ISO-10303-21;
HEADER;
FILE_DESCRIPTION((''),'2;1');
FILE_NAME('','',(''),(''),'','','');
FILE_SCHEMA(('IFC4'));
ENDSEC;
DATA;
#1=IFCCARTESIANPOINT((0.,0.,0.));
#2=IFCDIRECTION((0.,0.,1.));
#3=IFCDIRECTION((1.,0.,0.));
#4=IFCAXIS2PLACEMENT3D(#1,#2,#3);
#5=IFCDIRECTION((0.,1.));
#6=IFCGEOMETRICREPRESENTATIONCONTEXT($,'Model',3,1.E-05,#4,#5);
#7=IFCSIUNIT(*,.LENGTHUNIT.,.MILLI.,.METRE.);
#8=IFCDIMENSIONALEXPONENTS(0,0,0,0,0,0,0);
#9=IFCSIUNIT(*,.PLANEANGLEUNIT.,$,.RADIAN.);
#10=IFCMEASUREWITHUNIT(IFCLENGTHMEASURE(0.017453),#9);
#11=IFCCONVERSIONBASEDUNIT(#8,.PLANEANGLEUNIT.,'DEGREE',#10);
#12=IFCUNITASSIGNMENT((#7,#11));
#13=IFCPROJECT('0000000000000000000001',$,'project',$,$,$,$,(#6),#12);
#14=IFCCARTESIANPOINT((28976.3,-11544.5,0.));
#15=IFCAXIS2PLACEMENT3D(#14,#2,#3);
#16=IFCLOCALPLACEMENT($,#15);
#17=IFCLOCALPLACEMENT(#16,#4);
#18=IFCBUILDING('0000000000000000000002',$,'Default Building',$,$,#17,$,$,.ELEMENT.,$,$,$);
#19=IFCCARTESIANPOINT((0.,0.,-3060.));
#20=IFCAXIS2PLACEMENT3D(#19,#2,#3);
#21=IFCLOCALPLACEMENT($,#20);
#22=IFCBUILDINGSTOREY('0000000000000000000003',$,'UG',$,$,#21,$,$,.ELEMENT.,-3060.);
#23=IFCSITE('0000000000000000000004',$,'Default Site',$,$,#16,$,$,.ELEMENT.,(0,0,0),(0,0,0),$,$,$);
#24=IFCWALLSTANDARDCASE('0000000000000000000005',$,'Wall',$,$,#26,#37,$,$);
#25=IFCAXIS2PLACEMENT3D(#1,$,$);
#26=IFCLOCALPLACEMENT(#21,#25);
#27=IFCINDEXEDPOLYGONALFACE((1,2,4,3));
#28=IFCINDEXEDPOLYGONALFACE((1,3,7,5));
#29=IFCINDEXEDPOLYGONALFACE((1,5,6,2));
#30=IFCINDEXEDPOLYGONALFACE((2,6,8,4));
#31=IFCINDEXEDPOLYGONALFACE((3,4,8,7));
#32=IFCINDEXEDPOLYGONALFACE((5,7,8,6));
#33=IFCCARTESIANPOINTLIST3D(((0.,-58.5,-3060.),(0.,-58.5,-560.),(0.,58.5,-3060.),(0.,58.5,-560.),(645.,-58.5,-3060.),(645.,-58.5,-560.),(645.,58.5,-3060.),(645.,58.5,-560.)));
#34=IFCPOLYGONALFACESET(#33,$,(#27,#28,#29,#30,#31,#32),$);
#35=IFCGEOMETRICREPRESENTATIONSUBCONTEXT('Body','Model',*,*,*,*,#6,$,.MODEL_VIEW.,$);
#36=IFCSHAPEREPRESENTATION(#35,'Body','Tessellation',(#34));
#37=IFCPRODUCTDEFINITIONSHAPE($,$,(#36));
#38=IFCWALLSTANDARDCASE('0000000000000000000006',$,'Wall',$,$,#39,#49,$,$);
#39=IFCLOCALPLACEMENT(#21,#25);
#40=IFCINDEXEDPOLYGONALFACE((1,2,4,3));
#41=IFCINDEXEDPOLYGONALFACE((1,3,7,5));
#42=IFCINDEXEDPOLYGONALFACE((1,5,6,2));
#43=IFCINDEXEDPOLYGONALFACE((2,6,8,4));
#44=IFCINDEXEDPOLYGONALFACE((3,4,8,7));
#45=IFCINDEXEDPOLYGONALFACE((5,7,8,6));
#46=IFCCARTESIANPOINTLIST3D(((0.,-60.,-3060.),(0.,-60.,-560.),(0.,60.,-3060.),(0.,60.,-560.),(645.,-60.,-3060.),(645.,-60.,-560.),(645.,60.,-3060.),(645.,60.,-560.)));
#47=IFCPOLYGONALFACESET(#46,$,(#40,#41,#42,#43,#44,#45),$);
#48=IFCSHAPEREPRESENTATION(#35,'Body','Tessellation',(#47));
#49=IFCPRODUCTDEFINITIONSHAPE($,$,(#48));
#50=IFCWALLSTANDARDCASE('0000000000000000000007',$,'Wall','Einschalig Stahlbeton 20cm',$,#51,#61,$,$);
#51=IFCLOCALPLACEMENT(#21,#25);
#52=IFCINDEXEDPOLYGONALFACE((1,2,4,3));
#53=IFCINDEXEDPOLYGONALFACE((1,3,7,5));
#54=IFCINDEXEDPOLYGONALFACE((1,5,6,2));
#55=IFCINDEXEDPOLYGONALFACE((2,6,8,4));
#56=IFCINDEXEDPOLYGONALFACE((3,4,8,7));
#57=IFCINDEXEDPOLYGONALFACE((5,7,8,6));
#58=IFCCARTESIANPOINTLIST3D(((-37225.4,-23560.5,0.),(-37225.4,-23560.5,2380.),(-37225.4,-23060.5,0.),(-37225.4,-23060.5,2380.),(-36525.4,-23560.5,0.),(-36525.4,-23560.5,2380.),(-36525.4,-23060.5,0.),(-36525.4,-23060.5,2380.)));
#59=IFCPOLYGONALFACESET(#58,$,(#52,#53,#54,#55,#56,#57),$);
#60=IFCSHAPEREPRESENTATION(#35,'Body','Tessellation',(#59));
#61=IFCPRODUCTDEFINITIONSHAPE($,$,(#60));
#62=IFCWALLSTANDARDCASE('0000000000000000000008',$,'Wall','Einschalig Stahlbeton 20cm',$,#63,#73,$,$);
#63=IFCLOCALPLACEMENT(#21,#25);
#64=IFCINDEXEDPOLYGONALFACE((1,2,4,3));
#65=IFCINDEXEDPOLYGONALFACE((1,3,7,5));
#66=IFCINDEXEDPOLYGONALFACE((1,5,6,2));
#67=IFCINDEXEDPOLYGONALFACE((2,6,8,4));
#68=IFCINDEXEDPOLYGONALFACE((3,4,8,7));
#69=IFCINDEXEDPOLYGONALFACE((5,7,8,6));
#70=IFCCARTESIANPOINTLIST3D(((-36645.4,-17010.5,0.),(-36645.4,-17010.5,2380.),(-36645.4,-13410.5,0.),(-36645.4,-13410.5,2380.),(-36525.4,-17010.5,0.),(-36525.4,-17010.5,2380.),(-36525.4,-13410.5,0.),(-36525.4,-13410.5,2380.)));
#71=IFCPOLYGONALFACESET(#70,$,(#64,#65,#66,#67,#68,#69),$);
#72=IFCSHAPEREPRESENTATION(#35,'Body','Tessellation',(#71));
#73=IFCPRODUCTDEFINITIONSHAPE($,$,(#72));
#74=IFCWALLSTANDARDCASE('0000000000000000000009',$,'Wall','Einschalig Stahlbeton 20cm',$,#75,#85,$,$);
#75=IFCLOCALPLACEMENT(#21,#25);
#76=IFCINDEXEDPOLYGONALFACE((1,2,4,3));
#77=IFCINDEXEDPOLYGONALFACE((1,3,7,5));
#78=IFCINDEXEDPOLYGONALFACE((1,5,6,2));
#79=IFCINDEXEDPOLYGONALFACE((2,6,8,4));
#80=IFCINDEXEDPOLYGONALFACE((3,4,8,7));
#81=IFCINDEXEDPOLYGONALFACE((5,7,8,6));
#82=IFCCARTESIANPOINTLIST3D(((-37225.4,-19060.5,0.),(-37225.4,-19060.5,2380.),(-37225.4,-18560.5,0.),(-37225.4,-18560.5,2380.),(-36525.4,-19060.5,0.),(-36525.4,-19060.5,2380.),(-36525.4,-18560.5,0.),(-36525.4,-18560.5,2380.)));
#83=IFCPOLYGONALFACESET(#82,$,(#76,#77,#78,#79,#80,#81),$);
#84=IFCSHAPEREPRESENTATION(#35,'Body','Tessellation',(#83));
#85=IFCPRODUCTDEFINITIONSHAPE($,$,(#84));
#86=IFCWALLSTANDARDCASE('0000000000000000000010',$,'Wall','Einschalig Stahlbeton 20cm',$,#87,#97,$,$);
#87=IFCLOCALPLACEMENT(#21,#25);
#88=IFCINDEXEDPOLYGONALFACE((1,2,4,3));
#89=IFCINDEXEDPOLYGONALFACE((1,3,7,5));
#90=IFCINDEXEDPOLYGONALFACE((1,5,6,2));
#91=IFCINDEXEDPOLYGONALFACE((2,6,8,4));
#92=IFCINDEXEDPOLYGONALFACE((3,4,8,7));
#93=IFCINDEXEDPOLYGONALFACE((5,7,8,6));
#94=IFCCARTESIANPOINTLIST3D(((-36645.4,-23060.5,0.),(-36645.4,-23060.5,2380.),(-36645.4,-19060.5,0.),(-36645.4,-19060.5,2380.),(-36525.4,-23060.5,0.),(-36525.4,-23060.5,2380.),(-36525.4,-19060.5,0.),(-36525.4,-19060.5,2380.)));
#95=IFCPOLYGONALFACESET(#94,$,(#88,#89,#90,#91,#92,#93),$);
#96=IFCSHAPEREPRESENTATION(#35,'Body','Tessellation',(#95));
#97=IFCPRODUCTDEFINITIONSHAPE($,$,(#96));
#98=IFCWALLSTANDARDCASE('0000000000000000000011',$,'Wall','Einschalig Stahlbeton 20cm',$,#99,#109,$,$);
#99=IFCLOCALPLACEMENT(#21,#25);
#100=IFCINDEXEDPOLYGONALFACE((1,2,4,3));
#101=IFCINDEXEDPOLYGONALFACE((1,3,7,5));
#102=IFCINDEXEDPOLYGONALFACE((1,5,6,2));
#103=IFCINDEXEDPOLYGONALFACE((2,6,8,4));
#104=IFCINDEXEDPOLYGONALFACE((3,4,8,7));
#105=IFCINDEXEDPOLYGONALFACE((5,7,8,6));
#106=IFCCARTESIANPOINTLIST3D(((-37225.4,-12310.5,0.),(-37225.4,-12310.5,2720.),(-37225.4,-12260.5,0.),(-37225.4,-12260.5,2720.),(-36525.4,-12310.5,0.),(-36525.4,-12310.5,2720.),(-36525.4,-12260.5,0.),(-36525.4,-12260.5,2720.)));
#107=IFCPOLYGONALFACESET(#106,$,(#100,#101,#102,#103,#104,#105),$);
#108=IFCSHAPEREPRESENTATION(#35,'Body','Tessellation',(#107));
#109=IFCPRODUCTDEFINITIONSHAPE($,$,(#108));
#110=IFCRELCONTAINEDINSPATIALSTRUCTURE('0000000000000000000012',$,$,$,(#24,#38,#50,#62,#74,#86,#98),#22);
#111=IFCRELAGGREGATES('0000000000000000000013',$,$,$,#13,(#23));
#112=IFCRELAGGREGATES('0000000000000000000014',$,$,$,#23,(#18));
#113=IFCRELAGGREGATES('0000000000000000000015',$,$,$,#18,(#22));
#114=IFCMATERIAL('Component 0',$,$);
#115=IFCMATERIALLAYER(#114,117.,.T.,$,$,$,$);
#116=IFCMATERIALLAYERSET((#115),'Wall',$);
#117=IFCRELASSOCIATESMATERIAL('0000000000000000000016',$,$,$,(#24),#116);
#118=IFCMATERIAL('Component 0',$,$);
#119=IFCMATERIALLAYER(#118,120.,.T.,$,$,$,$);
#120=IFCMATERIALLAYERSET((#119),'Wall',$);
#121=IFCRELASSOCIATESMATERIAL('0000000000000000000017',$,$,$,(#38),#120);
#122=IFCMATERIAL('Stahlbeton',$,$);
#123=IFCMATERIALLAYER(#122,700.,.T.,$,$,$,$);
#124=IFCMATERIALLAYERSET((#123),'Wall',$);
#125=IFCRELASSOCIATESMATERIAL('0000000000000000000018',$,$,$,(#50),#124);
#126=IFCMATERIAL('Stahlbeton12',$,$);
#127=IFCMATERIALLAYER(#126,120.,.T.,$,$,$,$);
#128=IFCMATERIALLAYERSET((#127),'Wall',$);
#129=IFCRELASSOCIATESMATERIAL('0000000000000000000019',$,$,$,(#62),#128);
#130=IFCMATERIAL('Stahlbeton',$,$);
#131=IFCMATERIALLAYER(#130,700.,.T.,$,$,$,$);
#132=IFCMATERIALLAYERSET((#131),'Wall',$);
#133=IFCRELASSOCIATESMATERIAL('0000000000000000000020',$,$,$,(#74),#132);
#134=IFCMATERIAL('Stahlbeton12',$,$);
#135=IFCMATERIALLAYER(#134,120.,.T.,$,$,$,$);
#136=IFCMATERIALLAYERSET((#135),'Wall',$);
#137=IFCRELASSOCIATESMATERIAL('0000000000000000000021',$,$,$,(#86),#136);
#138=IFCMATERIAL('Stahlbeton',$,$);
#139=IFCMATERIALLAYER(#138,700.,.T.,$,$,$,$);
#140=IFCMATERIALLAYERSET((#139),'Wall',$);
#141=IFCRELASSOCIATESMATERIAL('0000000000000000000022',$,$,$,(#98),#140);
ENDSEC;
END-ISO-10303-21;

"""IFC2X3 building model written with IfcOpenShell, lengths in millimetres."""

from ifc_helpers import new_model, entity, si_unit, converted_unit, direction, frame, origin_with_axes, place, context, subcontext, project, spatial, polyline, outline, extrude, material, layer, layer_set, layer_usage, element, save


model = new_model("IFC2X3")

# Units and contexts
model_context = context("Model", 3, precision=1e-05, world=origin_with_axes(), true_north=direction((0.0, 1.0)))
body_context = subcontext(model_context, "Body", "Model", "MODEL_VIEW")
ifc_project = project(units=[si_unit("LENGTHUNIT", "METRE", prefix="MILLI"), converted_unit("PLANEANGLEUNIT", "DEGREE", entity("IfcLengthMeasure", 0.017453), si_unit("PLANEANGLEUNIT", "RADIAN"), dimensions=[0, 0, 0, 0, 0, 0, 0])], contexts=[model_context])

# Site, building, storey
site_placement = place(None, frame((28976.3, -11544.5, 0.0), z_axis=(0.0, 0.0, 1.0), x_axis=(1.0, 0.0, 0.0)))
site = spatial("IfcSite", under=ifc_project, at=site_placement, Name="Default Site", CompositionType="ELEMENT", RefLatitude=(0, 0, 0), RefLongitude=(0, 0, 0))
building_placement = place(site_placement, origin_with_axes())
building = spatial("IfcBuilding", under=site, at=building_placement, Name="Default Building", CompositionType="ELEMENT")
storey_placement = place(None, frame((0.0, 0.0, -3060.0), z_axis=(0.0, 0.0, 1.0), x_axis=(1.0, 0.0, 0.0)))
storey = spatial("IfcBuildingStorey", under=building, at=storey_placement, Name="UG", CompositionType="ELEMENT", Elevation=-3060.0)

# Walls
ifc_material_1 = material(Name="Component 0")
ifc_layer_1 = layer(ifc_material_1, 117.0, ventilated=True)
ifc_layer_set_1 = layer_set([ifc_layer_1], Name="Wall")
ifc_layer_usage_1 = layer_usage(ifc_layer_set_1, "AXIS2", "POSITIVE", -58.5)
wall_1_placement = place(storey_placement, frame((0.0, 0.0, -3060.0), z_axis=(0.0, 0.0, 1.0), x_axis=(1.0, 0.0, 0.0)))
element("IfcWallStandardCase", 1, at=wall_1_placement, inside=storey, material=ifc_layer_usage_1, Name="Wall", context=body_context, shape_type="SweptSolid", body=[
    extrude(outline(polyline([(0.0, -58.5), (0.0, 58.5), (645.0, 58.5), (645.0, -58.5), (0.0, -58.5)])), origin_with_axes(), (0.0, 0.0, 1.0), 2500.0),
])
ifc_material_2 = material(Name="Component 0")
ifc_layer_2 = layer(ifc_material_2, 120.0, ventilated=True)
ifc_layer_set_2 = layer_set([ifc_layer_2], Name="Wall")
ifc_layer_usage_2 = layer_usage(ifc_layer_set_2, "AXIS2", "POSITIVE", -60.0)
wall_2_placement = place(storey_placement, frame((0.0, 0.0, -3060.0), z_axis=(0.0, 0.0, 1.0), x_axis=(1.0, 0.0, 0.0)))
element("IfcWallStandardCase", 2, at=wall_2_placement, inside=storey, material=ifc_layer_usage_2, Name="Wall", context=body_context, shape_type="SweptSolid", body=[
    extrude(outline(polyline([(0.0, -60.0), (0.0, 60.0), (645.0, 60.0), (645.0, -60.0), (0.0, -60.0)])), origin_with_axes(), (0.0, 0.0, 1.0), 2500.0),
])
ifc_material_3 = material(Name="Stahlbeton")
ifc_layer_3 = layer(ifc_material_3, 700.0, ventilated=True)
ifc_layer_set_3 = layer_set([ifc_layer_3], Name="Wall")
ifc_layer_usage_3 = layer_usage(ifc_layer_set_3, "AXIS2", "POSITIVE", -350.0)
wall_3_placement = place(storey_placement, frame((-36875.4, -23560.5, 0.0), z_axis=(0.0, 0.0, 1.0), x_axis=(0.0, 1.0, 0.0)))
element("IfcWallStandardCase", 3, at=wall_3_placement, inside=storey, material=ifc_layer_usage_3, Name="Wall", Description="Einschalig Stahlbeton 20cm", context=body_context, shape_type="SweptSolid", body=[
    extrude(outline(polyline([(0.0, 350.0), (0.0, -350.0), (500.0, -350.0), (500.0, 350.0), (0.0, 350.0)])), origin_with_axes(), (0.0, 0.0, 1.0), 2380.0),
])
ifc_material_4 = material(Name="Stahlbeton12")
ifc_layer_4 = layer(ifc_material_4, 120.0, ventilated=True)
ifc_layer_set_4 = layer_set([ifc_layer_4], Name="Wall")
ifc_layer_usage_4 = layer_usage(ifc_layer_set_4, "AXIS2", "POSITIVE", -60.0)
wall_4_placement = place(storey_placement, frame((-36585.4, -13410.5, 0.0), z_axis=(0.0, 0.0, 1.0), x_axis=(0.0, -1.0, 0.0)))
element("IfcWallStandardCase", 4, at=wall_4_placement, inside=storey, material=ifc_layer_usage_4, Name="Wall", Description="Einschalig Stahlbeton 20cm", context=body_context, shape_type="SweptSolid", body=[
    extrude(outline(polyline([(0.0, -60.0), (0.0, 60.0), (3600.0, 60.0), (3600.0, -60.0), (0.0, -60.0)])), origin_with_axes(), (0.0, 0.0, 1.0), 2380.0),
])
ifc_material_5 = material(Name="Stahlbeton")
ifc_layer_5 = layer(ifc_material_5, 700.0, ventilated=True)
ifc_layer_set_5 = layer_set([ifc_layer_5], Name="Wall")
ifc_layer_usage_5 = layer_usage(ifc_layer_set_5, "AXIS2", "POSITIVE", -350.0)
wall_5_placement = place(storey_placement, frame((-36875.4, -19060.5, 0.0), z_axis=(0.0, 0.0, 1.0), x_axis=(0.0, 1.0, 0.0)))
element("IfcWallStandardCase", 5, at=wall_5_placement, inside=storey, material=ifc_layer_usage_5, Name="Wall", Description="Einschalig Stahlbeton 20cm", context=body_context, shape_type="SweptSolid", body=[
    extrude(outline(polyline([(0.0, -350.0), (0.0, 350.0), (500.0, 350.0), (500.0, -350.0), (0.0, -350.0)])), origin_with_axes(), (0.0, 0.0, 1.0), 2380.0),
])
ifc_material_6 = material(Name="Stahlbeton12")
ifc_layer_6 = layer(ifc_material_6, 120.0, ventilated=True)
ifc_layer_set_6 = layer_set([ifc_layer_6], Name="Wall")
ifc_layer_usage_6 = layer_usage(ifc_layer_set_6, "AXIS2", "POSITIVE", -60.0)
wall_6_placement = place(storey_placement, frame((-36585.4, -19060.5, 0.0), z_axis=(0.0, 0.0, 1.0), x_axis=(0.0, -1.0, 0.0)))
element("IfcWallStandardCase", 6, at=wall_6_placement, inside=storey, material=ifc_layer_usage_6, Name="Wall", Description="Einschalig Stahlbeton 20cm", context=body_context, shape_type="SweptSolid", body=[
    extrude(outline(polyline([(0.0, -60.0), (0.0, 60.0), (4000.0, 60.0), (4000.0, -60.0), (0.0, -60.0)])), origin_with_axes(), (0.0, 0.0, 1.0), 2380.0),
])
ifc_material_7 = material(Name="Stahlbeton")
ifc_layer_7 = layer(ifc_material_7, 700.0, ventilated=True)
ifc_layer_set_7 = layer_set([ifc_layer_7], Name="Wall")
ifc_layer_usage_7 = layer_usage(ifc_layer_set_7, "AXIS2", "POSITIVE", -350.0)
wall_7_placement = place(storey_placement, frame((-36875.4, -12310.5, 0.0), z_axis=(0.0, 0.0, 1.0), x_axis=(0.0, 1.0, 0.0)))
element("IfcWallStandardCase", 7, at=wall_7_placement, inside=storey, material=ifc_layer_usage_7, Name="Wall", Description="Einschalig Stahlbeton 20cm", context=body_context, shape_type="SweptSolid", body=[
    extrude(outline(polyline([(0.0, -350.0), (0.0, 350.0), (50.0, 350.0), (50.0, -350.0), (0.0, -350.0)])), origin_with_axes(), (0.0, 0.0, 1.0), 2720.0),
])

save(model, "model.ifc")
